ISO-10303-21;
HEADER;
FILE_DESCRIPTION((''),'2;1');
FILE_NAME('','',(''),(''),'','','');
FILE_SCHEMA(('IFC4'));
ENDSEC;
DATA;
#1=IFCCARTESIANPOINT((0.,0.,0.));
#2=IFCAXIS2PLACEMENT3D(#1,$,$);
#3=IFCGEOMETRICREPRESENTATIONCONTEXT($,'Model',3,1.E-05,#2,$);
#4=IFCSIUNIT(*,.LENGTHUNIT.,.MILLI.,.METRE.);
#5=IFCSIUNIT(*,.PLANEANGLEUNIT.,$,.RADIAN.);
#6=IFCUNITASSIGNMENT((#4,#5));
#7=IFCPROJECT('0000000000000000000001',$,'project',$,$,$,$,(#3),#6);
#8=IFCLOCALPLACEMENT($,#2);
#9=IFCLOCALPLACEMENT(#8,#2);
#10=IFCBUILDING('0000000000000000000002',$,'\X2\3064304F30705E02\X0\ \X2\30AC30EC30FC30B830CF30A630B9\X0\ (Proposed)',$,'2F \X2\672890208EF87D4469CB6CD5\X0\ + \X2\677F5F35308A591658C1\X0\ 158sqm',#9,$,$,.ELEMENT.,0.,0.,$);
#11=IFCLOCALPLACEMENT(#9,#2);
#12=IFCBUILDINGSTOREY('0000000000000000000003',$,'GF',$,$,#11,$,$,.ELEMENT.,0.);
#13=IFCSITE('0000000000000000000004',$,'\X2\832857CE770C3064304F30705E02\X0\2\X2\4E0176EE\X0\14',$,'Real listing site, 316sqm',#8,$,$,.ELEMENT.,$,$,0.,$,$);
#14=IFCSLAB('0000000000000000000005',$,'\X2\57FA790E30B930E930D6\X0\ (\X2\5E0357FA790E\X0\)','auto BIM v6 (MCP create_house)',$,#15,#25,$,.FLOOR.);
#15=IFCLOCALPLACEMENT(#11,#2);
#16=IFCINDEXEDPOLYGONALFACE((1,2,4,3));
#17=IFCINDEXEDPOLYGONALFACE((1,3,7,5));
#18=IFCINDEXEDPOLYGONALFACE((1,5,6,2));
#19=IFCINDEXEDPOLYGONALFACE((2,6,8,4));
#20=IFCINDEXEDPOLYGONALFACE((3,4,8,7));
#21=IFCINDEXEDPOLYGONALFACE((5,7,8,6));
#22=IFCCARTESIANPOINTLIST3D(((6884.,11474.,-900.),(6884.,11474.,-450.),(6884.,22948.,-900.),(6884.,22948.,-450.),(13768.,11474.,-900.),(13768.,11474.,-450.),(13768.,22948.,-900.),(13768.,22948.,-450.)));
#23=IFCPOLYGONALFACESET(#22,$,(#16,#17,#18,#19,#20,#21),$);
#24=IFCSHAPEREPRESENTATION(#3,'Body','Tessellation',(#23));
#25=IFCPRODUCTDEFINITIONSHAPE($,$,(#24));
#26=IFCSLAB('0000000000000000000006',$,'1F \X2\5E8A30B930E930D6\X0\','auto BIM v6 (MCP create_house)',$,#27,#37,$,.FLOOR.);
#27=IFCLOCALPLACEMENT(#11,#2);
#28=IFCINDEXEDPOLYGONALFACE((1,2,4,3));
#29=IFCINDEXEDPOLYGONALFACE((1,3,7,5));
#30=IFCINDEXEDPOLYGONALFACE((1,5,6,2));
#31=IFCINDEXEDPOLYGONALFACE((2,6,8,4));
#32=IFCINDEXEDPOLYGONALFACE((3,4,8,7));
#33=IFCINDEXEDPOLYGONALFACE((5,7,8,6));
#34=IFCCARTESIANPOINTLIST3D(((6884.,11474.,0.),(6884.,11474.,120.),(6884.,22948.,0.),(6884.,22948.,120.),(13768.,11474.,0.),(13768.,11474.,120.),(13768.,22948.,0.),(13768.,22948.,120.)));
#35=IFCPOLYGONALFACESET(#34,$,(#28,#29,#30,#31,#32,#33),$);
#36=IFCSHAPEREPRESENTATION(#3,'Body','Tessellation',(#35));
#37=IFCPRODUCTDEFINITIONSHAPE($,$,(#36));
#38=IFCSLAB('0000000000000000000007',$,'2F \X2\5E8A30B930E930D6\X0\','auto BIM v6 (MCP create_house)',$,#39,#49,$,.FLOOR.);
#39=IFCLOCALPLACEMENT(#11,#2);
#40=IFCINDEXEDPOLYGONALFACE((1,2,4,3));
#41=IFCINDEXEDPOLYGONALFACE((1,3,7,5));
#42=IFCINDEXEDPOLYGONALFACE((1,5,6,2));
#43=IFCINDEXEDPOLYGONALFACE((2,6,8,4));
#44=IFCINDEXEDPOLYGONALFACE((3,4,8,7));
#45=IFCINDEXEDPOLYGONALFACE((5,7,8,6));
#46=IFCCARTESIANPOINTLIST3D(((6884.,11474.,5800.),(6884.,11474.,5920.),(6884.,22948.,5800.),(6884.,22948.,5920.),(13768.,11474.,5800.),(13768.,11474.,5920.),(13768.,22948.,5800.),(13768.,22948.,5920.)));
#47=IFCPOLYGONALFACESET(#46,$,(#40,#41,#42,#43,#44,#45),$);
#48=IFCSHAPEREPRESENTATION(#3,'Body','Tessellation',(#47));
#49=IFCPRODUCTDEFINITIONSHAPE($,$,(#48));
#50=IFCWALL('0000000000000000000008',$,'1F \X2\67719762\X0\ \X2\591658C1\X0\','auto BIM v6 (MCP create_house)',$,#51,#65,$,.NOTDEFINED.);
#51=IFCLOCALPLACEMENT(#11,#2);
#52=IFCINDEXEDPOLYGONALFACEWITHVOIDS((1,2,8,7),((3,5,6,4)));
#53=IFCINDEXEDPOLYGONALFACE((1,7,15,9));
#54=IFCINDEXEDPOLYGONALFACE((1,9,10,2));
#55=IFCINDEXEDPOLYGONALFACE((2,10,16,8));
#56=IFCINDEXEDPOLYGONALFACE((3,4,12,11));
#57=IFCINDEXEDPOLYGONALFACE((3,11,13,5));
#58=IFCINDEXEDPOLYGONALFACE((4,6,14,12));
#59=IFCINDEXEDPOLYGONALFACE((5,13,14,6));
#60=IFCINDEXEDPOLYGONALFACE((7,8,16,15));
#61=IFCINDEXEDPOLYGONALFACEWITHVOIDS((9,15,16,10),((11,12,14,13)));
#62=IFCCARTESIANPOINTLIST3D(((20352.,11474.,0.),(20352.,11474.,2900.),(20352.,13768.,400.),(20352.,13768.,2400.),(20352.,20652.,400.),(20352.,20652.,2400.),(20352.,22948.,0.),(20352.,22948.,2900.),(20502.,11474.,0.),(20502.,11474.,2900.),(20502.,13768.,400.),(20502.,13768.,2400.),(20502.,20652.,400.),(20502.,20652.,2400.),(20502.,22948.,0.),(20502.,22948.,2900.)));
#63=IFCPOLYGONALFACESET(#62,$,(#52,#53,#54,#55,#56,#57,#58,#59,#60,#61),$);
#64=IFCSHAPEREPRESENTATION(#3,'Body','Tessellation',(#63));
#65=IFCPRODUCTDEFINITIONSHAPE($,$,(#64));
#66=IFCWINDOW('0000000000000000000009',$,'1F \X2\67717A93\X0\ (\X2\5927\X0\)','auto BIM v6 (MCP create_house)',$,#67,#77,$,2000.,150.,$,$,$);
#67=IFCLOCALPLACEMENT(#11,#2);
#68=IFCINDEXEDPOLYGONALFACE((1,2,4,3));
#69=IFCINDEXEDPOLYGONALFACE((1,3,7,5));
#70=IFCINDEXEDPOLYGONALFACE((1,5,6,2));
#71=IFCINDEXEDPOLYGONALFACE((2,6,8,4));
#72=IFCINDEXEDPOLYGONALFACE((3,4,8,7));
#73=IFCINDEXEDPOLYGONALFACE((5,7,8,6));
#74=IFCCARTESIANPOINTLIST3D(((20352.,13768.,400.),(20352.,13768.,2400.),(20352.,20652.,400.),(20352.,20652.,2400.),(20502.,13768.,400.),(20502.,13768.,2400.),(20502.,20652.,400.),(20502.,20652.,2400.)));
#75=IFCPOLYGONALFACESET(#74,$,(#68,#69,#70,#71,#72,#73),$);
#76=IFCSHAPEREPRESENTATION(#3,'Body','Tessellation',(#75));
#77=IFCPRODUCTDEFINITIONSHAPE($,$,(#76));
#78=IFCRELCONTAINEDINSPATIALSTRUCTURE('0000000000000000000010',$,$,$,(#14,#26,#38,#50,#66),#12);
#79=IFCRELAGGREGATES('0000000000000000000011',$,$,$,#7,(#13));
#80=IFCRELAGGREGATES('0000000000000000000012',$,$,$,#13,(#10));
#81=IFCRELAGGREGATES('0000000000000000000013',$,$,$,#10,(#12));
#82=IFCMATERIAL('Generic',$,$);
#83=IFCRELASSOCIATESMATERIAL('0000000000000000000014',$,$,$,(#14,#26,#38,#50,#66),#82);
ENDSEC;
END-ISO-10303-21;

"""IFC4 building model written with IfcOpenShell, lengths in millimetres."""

from ifc_helpers import new_model, si_unit, frame, frame_2d, origin, place, context, project, spatial, rectangle, extrude, material, element, fill, save


model = new_model("IFC4")

# Units and contexts
model_context = context("Model", 3, precision=1e-05, world=origin())
ifc_project = project(units=[si_unit("LENGTHUNIT", "METRE", prefix="MILLI"), si_unit("PLANEANGLEUNIT", "RADIAN")], contexts=[model_context])

# Site, building, storey
site_placement = place(None, origin())
site = spatial("IfcSite", under=ifc_project, at=site_placement, Name="茨城県つくば市2丁目14", ObjectType="Real listing site, 316sqm", CompositionType="ELEMENT", RefElevation=0.0)
building_placement = place(site_placement, origin())
building = spatial("IfcBuilding", under=site, at=building_placement, Name="つくば市 ガレージハウス (Proposed)", ObjectType="2F 木造軸組構法 + 板張り外壁 158sqm", CompositionType="ELEMENT", ElevationOfRefHeight=0.0, ElevationOfTerrain=0.0)
storey_placement = place(building_placement, origin())
storey = spatial("IfcBuildingStorey", under=building, at=storey_placement, Name="GF", CompositionType="ELEMENT", Elevation=0.0)

# Slabs
ifc_material = material(Name="Generic")
slab_1_placement = place(storey_placement, frame((3442.0, 5737.0, -450.0)))
element("IfcSlab", 1, at=slab_1_placement, inside=storey, material=ifc_material, Name="基礎スラブ (布基礎)", Description="auto BIM v6 (MCP create_house)", PredefinedType="FLOOR", context=model_context, shape_type="SweptSolid", body=[
    extrude(rectangle(XDim=6884.0, YDim=11474.0, at=frame_2d((3442.0, 5737.0))), frame((3442.0, 5737.0, -450.0)), (0.0, 0.0, 1.0), 450.0),
])
slab_2_placement = place(storey_placement, frame((3442.0, 5737.0, 0.0)))
element("IfcSlab", 2, at=slab_2_placement, inside=storey, material=ifc_material, Name="1F 床スラブ", Description="auto BIM v6 (MCP create_house)", PredefinedType="FLOOR", context=model_context, shape_type="SweptSolid", body=[
    extrude(rectangle(XDim=6884.0, YDim=11474.0, at=frame_2d((3442.0, 5737.0))), frame((3442.0, 5737.0, 0.0)), (0.0, 0.0, 1.0), 120.0),
])
slab_3_placement = place(storey_placement, frame((3442.0, 5737.0, 2900.0)))
element("IfcSlab", 3, at=slab_3_placement, inside=storey, material=ifc_material, Name="2F 床スラブ", Description="auto BIM v6 (MCP create_house)", PredefinedType="FLOOR", context=model_context, shape_type="SweptSolid", body=[
    extrude(rectangle(XDim=6884.0, YDim=11474.0, at=frame_2d((3442.0, 5737.0))), frame((3442.0, 5737.0, 2900.0)), (0.0, 0.0, 1.0), 120.0),
])

# Wall, opening, window
wall_1_placement = place(storey_placement, frame((10176.0, 5737.0, 0.0)))
wall_1 = element("IfcWall", 4, at=wall_1_placement, inside=storey, material=ifc_material, Name="1F 東面 外壁", Description="auto BIM v6 (MCP create_house)", PredefinedType="NOTDEFINED", context=model_context, shape_type="SweptSolid", body=[
    extrude(rectangle(XDim=150.0, YDim=11474.0, at=frame_2d((75.0, 5737.0))), frame((10176.0, 5737.0, 0.0)), (0.0, 0.0, 1.0), 2900.0),
])
opening_1_placement = place(storey_placement, frame((10176.0, 6884.0, 200.0)))
opening_1 = element("IfcOpeningElement", 5, at=opening_1_placement, cuts=wall_1, PredefinedType="NOTDEFINED", context=model_context, shape_type="SweptSolid", body=[
    extrude(rectangle(XDim=150.0, YDim=6884.0, at=frame_2d((75.0, 3442.0))), frame((10176.0, 6884.0, 200.0)), (0.0, 0.0, 1.0), 2000.0),
])
window_1_placement = place(storey_placement, frame((10176.0, 6884.0, 200.0)))
window_1 = element("IfcWindow", 6, at=window_1_placement, inside=storey, material=ifc_material, Name="1F 東窓 (大)", Description="auto BIM v6 (MCP create_house)", OverallHeight=2000.0, OverallWidth=150.0, context=model_context, shape_type="SweptSolid", body=[
    extrude(rectangle(XDim=150.0, YDim=6884.0, at=frame_2d((75.0, 3442.0))), frame((10176.0, 6884.0, 200.0)), (0.0, 0.0, 1.0), 2000.0),
])
fill(opening_1, window_1)

save(model, "model.ifc")
